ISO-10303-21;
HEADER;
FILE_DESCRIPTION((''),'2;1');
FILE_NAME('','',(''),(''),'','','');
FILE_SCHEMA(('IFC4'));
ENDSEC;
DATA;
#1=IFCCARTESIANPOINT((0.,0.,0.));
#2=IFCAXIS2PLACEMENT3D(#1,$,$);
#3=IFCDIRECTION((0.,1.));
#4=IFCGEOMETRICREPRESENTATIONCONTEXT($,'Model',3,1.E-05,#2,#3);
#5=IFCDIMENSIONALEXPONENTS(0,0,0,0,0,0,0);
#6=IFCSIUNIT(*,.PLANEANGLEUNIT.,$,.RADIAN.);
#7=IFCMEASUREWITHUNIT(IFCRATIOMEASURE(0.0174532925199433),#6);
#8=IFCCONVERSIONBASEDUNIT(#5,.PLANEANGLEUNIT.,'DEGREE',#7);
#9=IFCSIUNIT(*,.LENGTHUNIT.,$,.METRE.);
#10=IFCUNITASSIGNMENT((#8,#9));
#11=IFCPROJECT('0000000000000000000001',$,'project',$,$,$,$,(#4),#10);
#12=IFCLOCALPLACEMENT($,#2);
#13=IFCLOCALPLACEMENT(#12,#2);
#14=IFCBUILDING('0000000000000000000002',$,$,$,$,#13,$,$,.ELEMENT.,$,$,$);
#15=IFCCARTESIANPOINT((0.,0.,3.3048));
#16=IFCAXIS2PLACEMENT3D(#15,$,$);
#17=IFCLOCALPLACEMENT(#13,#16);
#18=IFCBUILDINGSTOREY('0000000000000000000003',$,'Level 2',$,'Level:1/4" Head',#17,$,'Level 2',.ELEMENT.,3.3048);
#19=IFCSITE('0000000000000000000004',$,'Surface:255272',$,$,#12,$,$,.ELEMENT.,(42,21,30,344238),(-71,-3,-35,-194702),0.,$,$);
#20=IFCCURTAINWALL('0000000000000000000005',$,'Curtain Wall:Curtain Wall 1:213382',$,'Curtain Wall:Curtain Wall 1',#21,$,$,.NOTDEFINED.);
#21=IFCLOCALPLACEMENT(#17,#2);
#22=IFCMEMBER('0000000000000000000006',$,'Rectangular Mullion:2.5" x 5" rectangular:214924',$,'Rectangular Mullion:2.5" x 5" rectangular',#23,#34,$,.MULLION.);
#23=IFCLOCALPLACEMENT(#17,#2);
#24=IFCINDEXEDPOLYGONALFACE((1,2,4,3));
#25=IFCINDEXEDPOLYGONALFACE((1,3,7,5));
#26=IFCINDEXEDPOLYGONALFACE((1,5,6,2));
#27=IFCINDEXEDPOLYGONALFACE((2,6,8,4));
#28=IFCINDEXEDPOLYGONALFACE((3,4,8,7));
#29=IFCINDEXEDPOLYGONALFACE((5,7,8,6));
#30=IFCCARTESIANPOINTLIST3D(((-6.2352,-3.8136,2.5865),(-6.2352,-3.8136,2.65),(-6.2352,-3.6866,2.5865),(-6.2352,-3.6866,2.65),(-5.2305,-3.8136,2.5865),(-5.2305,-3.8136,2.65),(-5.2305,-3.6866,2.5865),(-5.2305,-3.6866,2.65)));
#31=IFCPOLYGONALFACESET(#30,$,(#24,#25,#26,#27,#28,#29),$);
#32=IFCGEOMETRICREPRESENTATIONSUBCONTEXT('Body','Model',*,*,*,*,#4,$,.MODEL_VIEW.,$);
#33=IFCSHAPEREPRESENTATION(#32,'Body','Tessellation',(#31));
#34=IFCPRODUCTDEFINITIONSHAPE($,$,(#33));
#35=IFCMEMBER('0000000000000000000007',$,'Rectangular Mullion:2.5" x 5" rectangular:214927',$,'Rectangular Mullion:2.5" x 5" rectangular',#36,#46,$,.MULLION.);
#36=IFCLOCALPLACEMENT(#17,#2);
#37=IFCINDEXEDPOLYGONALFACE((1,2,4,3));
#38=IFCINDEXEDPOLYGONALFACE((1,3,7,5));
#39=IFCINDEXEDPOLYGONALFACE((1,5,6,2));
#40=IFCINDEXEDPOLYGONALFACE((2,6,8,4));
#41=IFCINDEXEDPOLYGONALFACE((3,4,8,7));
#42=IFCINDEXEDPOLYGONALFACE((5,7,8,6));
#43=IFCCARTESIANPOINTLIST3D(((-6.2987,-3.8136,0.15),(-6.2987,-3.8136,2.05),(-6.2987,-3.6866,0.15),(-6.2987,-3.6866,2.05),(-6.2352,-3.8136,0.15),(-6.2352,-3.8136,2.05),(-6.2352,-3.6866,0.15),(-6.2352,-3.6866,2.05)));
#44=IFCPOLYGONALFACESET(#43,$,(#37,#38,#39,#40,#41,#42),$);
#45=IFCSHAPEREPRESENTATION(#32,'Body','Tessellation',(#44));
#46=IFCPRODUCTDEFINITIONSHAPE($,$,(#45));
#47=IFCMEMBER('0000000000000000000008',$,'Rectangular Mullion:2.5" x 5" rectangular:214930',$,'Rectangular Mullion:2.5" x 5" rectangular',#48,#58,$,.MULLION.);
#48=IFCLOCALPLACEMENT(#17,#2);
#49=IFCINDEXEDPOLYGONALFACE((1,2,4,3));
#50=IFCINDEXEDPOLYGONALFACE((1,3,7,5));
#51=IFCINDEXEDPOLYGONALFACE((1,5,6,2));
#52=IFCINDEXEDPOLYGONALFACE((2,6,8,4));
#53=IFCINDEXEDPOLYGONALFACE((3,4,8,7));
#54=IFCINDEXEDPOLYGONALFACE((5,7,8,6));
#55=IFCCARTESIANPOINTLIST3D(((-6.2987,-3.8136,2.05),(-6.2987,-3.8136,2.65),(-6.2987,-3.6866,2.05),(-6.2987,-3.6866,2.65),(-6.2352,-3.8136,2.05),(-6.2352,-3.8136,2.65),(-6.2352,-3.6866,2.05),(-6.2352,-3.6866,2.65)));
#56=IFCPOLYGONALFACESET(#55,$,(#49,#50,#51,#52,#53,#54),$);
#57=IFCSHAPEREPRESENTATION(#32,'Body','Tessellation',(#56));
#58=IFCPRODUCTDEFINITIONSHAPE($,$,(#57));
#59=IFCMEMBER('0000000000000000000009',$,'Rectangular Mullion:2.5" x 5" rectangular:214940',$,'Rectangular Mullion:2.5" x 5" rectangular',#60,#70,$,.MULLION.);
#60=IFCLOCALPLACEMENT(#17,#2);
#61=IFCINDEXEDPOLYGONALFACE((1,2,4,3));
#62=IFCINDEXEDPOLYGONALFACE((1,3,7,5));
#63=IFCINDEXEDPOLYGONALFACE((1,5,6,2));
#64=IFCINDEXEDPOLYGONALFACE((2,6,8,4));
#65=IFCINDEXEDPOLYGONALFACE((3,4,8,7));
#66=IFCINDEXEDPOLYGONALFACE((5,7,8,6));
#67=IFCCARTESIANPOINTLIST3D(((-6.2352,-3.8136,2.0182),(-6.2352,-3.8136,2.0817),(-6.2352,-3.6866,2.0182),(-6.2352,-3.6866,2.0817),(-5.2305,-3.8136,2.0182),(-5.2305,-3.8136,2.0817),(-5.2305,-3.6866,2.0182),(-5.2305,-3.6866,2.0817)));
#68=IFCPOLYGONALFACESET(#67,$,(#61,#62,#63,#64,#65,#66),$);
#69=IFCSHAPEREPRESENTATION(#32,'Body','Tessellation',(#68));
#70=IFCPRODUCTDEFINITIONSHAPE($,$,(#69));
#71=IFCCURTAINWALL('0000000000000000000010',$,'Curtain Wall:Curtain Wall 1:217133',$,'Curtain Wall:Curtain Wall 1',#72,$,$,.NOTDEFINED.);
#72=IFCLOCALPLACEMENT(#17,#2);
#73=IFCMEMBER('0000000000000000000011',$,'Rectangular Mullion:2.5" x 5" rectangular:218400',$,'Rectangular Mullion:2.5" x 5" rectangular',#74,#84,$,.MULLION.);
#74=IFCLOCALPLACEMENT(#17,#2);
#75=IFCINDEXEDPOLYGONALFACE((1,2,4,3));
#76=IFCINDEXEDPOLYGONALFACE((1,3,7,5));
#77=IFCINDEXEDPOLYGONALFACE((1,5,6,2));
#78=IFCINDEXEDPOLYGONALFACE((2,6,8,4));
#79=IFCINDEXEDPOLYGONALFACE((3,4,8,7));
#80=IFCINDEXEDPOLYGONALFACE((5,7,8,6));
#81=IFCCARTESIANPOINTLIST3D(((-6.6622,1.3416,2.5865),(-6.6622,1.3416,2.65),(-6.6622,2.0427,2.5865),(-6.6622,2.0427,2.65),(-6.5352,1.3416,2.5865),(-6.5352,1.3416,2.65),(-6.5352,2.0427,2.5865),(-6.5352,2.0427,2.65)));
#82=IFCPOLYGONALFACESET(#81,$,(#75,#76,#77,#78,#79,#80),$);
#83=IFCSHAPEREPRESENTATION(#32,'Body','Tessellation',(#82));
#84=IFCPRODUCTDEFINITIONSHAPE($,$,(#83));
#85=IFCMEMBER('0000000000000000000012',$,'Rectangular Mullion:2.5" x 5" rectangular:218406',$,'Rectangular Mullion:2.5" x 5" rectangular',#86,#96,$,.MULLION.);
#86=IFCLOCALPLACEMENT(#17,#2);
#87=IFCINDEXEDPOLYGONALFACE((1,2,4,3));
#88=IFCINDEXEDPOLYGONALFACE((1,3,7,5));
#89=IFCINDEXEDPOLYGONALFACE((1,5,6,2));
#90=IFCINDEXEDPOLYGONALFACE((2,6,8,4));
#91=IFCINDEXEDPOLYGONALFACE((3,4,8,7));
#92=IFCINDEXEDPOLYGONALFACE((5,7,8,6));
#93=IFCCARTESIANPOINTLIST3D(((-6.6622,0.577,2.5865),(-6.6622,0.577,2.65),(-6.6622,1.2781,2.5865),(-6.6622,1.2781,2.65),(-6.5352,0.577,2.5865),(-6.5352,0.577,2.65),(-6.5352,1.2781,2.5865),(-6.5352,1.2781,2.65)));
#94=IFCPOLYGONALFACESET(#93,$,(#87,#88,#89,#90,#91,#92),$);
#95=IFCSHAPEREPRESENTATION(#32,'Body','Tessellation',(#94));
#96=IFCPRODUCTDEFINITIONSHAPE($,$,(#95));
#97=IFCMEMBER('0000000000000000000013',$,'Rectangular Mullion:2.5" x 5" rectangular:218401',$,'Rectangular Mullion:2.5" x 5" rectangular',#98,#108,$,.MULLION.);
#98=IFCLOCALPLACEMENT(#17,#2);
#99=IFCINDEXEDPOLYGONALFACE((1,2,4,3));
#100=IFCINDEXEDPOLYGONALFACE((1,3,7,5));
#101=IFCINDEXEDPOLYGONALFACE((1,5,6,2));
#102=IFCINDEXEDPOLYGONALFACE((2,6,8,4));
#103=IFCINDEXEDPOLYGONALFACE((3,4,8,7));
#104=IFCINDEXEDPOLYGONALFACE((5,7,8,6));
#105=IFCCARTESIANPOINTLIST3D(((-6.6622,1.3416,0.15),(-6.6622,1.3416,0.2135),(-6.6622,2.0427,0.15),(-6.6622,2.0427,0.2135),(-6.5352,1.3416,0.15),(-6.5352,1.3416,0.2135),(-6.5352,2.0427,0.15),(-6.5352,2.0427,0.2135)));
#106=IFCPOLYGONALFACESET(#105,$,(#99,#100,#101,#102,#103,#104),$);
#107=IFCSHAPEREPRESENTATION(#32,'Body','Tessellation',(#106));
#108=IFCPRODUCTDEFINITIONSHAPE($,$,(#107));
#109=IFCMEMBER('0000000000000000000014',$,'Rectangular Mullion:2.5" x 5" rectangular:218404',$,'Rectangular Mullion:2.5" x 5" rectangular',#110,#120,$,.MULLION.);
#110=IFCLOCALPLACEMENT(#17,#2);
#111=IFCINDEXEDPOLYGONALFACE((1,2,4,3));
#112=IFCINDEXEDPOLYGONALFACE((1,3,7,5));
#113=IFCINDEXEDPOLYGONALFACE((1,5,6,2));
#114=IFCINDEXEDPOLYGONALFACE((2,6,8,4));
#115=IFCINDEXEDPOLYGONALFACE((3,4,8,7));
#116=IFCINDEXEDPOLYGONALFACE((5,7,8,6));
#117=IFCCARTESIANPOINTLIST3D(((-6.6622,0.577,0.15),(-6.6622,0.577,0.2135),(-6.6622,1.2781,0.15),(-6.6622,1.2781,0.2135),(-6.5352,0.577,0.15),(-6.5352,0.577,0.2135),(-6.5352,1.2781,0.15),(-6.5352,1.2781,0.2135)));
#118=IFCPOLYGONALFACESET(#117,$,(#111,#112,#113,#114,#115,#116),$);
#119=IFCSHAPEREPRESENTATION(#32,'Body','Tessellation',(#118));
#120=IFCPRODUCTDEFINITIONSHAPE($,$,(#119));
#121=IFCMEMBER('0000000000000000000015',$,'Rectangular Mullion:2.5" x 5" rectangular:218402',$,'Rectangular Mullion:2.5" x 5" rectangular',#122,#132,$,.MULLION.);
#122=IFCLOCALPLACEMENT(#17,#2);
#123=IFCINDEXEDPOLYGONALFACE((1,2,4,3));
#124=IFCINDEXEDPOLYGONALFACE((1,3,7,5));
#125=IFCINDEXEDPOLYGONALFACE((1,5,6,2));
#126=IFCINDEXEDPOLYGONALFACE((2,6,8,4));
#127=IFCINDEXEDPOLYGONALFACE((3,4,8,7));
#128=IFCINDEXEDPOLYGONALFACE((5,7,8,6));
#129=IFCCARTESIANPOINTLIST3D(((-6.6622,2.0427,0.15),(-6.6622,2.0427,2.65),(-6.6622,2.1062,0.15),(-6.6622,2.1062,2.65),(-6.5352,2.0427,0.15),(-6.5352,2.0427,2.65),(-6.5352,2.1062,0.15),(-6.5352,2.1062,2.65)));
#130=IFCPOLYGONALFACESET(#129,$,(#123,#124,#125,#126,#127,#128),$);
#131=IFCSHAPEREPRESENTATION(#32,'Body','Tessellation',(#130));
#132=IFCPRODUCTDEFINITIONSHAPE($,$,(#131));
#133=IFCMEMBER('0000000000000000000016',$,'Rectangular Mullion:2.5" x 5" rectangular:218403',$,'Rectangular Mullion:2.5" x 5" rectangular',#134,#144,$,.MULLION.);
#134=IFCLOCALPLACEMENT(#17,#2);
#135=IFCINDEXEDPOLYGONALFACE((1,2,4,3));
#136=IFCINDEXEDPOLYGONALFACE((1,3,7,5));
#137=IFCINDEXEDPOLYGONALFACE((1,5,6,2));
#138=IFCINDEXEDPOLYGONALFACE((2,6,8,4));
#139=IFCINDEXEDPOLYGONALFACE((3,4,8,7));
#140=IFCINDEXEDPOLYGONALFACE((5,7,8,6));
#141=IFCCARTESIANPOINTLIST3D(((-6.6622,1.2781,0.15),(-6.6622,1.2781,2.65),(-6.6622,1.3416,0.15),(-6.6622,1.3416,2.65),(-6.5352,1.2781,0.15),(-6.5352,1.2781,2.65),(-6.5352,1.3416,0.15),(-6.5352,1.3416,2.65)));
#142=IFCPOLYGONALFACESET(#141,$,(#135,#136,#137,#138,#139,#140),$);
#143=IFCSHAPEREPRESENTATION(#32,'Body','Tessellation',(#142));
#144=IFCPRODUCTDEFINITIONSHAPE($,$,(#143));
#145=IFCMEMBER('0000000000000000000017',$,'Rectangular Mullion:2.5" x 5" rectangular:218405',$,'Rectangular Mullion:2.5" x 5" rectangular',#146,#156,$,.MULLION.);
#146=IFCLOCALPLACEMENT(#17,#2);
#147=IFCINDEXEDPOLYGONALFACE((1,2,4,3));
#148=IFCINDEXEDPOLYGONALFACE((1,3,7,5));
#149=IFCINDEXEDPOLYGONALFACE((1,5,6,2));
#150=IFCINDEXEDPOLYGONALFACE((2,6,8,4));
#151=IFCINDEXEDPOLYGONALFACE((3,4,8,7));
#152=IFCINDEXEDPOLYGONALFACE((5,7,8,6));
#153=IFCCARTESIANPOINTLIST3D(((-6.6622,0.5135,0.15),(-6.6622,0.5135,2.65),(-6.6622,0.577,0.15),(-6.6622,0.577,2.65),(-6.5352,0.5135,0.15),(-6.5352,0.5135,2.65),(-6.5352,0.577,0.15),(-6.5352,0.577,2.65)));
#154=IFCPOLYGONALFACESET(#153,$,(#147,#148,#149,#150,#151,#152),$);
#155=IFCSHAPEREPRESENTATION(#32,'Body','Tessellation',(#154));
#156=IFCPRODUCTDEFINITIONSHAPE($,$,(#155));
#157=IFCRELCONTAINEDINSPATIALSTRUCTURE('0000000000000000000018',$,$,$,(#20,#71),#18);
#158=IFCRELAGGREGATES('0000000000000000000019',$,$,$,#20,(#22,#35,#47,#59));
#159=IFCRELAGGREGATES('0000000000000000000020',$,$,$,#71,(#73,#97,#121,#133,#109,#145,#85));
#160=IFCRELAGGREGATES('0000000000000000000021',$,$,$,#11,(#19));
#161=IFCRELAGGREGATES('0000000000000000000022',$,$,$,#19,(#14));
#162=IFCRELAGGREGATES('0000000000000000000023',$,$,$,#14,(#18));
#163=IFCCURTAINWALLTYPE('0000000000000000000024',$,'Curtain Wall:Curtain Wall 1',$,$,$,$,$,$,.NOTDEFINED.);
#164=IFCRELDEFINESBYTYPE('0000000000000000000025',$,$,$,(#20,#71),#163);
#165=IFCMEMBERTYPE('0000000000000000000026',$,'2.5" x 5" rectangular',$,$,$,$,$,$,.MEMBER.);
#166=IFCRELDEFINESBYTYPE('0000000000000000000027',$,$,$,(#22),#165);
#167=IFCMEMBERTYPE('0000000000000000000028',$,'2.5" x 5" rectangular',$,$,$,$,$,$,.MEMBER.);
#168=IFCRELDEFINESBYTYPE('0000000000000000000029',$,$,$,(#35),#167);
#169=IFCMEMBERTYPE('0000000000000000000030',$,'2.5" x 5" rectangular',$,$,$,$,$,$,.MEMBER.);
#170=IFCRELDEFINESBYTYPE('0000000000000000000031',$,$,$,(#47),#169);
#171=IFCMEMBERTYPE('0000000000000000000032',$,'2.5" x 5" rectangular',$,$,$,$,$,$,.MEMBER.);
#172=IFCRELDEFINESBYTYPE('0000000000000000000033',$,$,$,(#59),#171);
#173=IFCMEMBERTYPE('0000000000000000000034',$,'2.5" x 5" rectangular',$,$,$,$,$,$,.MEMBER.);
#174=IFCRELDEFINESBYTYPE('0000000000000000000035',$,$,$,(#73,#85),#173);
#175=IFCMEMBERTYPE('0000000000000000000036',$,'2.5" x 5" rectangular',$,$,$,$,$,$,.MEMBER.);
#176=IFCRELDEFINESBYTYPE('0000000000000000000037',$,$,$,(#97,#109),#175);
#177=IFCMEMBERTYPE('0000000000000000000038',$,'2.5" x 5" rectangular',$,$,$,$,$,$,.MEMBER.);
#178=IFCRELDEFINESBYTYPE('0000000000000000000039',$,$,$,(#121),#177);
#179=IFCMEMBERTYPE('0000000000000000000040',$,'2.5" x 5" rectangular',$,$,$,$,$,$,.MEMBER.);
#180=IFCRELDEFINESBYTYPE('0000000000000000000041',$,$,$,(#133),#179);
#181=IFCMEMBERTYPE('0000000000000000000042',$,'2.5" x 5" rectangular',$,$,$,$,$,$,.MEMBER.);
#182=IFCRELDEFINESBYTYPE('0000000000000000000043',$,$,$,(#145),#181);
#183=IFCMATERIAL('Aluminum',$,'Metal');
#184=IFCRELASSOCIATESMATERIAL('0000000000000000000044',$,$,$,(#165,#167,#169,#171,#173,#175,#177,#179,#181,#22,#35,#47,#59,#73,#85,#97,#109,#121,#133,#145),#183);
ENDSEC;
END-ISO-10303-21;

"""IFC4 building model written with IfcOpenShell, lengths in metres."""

from ifc_helpers import new_model, entity, si_unit, converted_unit, direction, frame, origin, origin_2d_with_axis, place, context, subcontext, project, spatial, rectangle, extrude, source, transform, mapped, material, material_profile, profile_set, profile_usage, type_object, type_shapes, element, aggregate, save


model = new_model("IFC4")

# Units and contexts
model_context = context("Model", 3, precision=1e-05, world=origin(), true_north=direction((0.0, 1.0)))
body_context = subcontext(model_context, "Body", "Model", "MODEL_VIEW")
ifc_project = project(units=[converted_unit("PLANEANGLEUNIT", "DEGREE", entity("IfcRatioMeasure", 0.0174532925199433), si_unit("PLANEANGLEUNIT", "RADIAN"), dimensions=[0, 0, 0, 0, 0, 0, 0]), si_unit("LENGTHUNIT", "METRE")], contexts=[model_context])

# Site, building, storey
site_placement = place(None, origin())
site = spatial("IfcSite", under=ifc_project, at=site_placement, Name="Surface:255272", CompositionType="ELEMENT", RefLatitude=(42, 21, 30, 344238), RefLongitude=(-71, -3, -35, -194702), RefElevation=0.0)
building_placement = place(site_placement, origin())
building = spatial("IfcBuilding", under=site, at=building_placement, CompositionType="ELEMENT")
storey_placement = place(building_placement, frame((0.0, 0.0, 3.3048)))
storey = spatial("IfcBuildingStorey", under=building, at=storey_placement, Name="Level 2", ObjectType="Level:1/4\" Head", LongName="Level 2", CompositionType="ELEMENT", Elevation=3.3048)

# Curtain walls, members
curtain_wall_type = type_object("IfcCurtainWallType", Name="Curtain Wall:Curtain Wall 1", PredefinedType="NOTDEFINED")
curtain_wall_1_placement = place(storey_placement, frame((0.0, 0.0, -3.3048)))
curtain_wall_1 = element("IfcCurtainWall", 1, at=curtain_wall_1_placement, inside=storey, type_object=curtain_wall_type, Name="Curtain Wall:Curtain Wall 1:213382", ObjectType="Curtain Wall:Curtain Wall 1", PredefinedType="NOTDEFINED")
ifc_material_1 = material(Name="Aluminum", Category="Metal")
ifc_material_profile = material_profile(ifc_material_1, rectangle(XDim=0.127, YDim=0.0635, at=origin_2d_with_axis()), Name="2.5\" x 5\" rectangular")
ifc_profile_set = profile_set([ifc_material_profile], Name="2.5\" x 5\" rectangular")
ifc_profile_usage_1 = profile_usage(ifc_profile_set)
member_type_1 = type_object("IfcMemberType", Name="2.5\" x 5\" rectangular", PredefinedType="MEMBER", material=ifc_profile_set)
shared_shape_1 = source(origin(), body_context, "Body", "SweptSolid", [
    extrude(rectangle(XDim=0.127, YDim=0.0635, at=origin_2d_with_axis()), frame((-0.0318, 0.0, -1.0048), z_axis=(0.0, 0.0, 1.0), x_axis=(0.0, -1.0, 0.0)), (0.0, 0.0, 1.0), 1.0048),
])
type_shapes(member_type_1, [shared_shape_1])
member_1_placement = place(storey_placement, frame((-6.2352, -3.7501, 2.65), z_axis=(-1.0, 0.000007, 0.0), x_axis=(0.0, 0.0, 1.0)))
member_1 = element("IfcMember", 2, at=member_1_placement, type_object=member_type_1, material=ifc_profile_usage_1, Name="Rectangular Mullion:2.5\" x 5\" rectangular:214924", ObjectType="Rectangular Mullion:2.5\" x 5\" rectangular", PredefinedType="MULLION", context=body_context, shape_type="MappedRepresentation", body=[
    mapped(shared_shape_1, transform((0.0, 0.0, 0.0), scale=1.0)),
])
ifc_profile_usage_2 = profile_usage(ifc_profile_set)
member_type_2 = type_object("IfcMemberType", Name="2.5\" x 5\" rectangular", PredefinedType="MEMBER", material=ifc_profile_set)
shared_shape_2 = source(origin(), body_context, "Body", "SweptSolid", [
    extrude(rectangle(XDim=0.127, YDim=0.0635, at=origin_2d_with_axis()), frame((-0.0318, 0.0, -1.9), z_axis=(0.0, 0.0, 1.0), x_axis=(0.0, -1.0, 0.0)), (0.0, 0.0, 1.0), 1.9),
])
type_shapes(member_type_2, [shared_shape_2])
member_2_placement = place(storey_placement, frame((-6.2987, -3.7501, 0.15), z_axis=(0.0, 0.0, -1.0), x_axis=(-1.0, 0.000007, 0.0)))
member_2 = element("IfcMember", 3, at=member_2_placement, type_object=member_type_2, material=ifc_profile_usage_2, Name="Rectangular Mullion:2.5\" x 5\" rectangular:214927", ObjectType="Rectangular Mullion:2.5\" x 5\" rectangular", PredefinedType="MULLION", context=body_context, shape_type="MappedRepresentation", body=[
    mapped(shared_shape_2, transform((0.0, 0.0, 0.0), scale=1.0)),
])
ifc_profile_usage_3 = profile_usage(ifc_profile_set)
member_type_3 = type_object("IfcMemberType", Name="2.5\" x 5\" rectangular", PredefinedType="MEMBER", material=ifc_profile_set)
shared_shape_3 = source(origin(), body_context, "Body", "SweptSolid", [
    extrude(rectangle(XDim=0.127, YDim=0.0635, at=origin_2d_with_axis()), frame((-0.0318, 0.0, -0.6), z_axis=(0.0, 0.0, 1.0), x_axis=(0.0, -1.0, 0.0)), (0.0, 0.0, 1.0), 0.6),
])
type_shapes(member_type_3, [shared_shape_3])
member_3_placement = place(storey_placement, frame((-6.2987, -3.7501, 2.05), z_axis=(0.0, 0.0, -1.0), x_axis=(-1.0, 0.000007, 0.0)))
member_3 = element("IfcMember", 4, at=member_3_placement, type_object=member_type_3, material=ifc_profile_usage_3, Name="Rectangular Mullion:2.5\" x 5\" rectangular:214930", ObjectType="Rectangular Mullion:2.5\" x 5\" rectangular", PredefinedType="MULLION", context=body_context, shape_type="MappedRepresentation", body=[
    mapped(shared_shape_3, transform((0.0, 0.0, 0.0), scale=1.0)),
])
ifc_profile_usage_4 = profile_usage(ifc_profile_set)
member_type_4 = type_object("IfcMemberType", Name="2.5\" x 5\" rectangular", PredefinedType="MEMBER", material=ifc_profile_set)
shared_shape_4 = source(origin(), body_context, "Body", "SweptSolid", [
    extrude(rectangle(XDim=0.127, YDim=0.0635, at=origin_2d_with_axis()), frame((0.0, 0.0, -1.0048), z_axis=(0.0, 0.0, 1.0), x_axis=(0.0, -1.0, 0.0)), (0.0, 0.0, 1.0), 1.0048),
])
type_shapes(member_type_4, [shared_shape_4])
member_4_placement = place(storey_placement, frame((-6.2352, -3.7501, 2.05), z_axis=(-1.0, 0.000007, 0.0), x_axis=(0.0, 0.0, 1.0)))
member_4 = element("IfcMember", 5, at=member_4_placement, type_object=member_type_4, material=ifc_profile_usage_4, Name="Rectangular Mullion:2.5\" x 5\" rectangular:214940", ObjectType="Rectangular Mullion:2.5\" x 5\" rectangular", PredefinedType="MULLION", context=body_context, shape_type="MappedRepresentation", body=[
    mapped(shared_shape_4, transform((0.0, 0.0, 0.0), scale=1.0)),
])
curtain_wall_2_placement = place(storey_placement, frame((0.0, 0.0, -3.3048)))
curtain_wall_2 = element("IfcCurtainWall", 6, at=curtain_wall_2_placement, inside=storey, type_object=curtain_wall_type, Name="Curtain Wall:Curtain Wall 1:217133", ObjectType="Curtain Wall:Curtain Wall 1", PredefinedType="NOTDEFINED")
ifc_profile_usage_5 = profile_usage(ifc_profile_set)
member_type_5 = type_object("IfcMemberType", Name="2.5\" x 5\" rectangular", PredefinedType="MEMBER", material=ifc_profile_set)
shared_shape_5 = source(origin(), body_context, "Body", "SweptSolid", [
    extrude(rectangle(XDim=0.127, YDim=0.0635, at=origin_2d_with_axis()), frame((-0.0318, 0.0, -0.7011), z_axis=(0.0, 0.0, 1.0), x_axis=(0.0, -1.0, 0.0)), (0.0, 0.0, 1.0), 0.7011),
])
type_shapes(member_type_5, [shared_shape_5])
member_5_placement = place(storey_placement, frame((-6.5987, 2.0427, 2.65), z_axis=(0.000007, 1.0, 0.0), x_axis=(0.0, 0.0, 1.0)))
member_5 = element("IfcMember", 7, at=member_5_placement, type_object=member_type_5, material=ifc_profile_usage_5, Name="Rectangular Mullion:2.5\" x 5\" rectangular:218400", ObjectType="Rectangular Mullion:2.5\" x 5\" rectangular", PredefinedType="MULLION", context=body_context, shape_type="MappedRepresentation", body=[
    mapped(shared_shape_5, transform((0.0, 0.0, 0.0), scale=1.0)),
])
ifc_profile_usage_6 = profile_usage(ifc_profile_set)
member_6_placement = place(storey_placement, frame((-6.5987, 1.2781, 2.65), z_axis=(0.000007, 1.0, 0.0), x_axis=(0.0, 0.0, 1.0)))
member_6 = element("IfcMember", 8, at=member_6_placement, type_object=member_type_5, material=ifc_profile_usage_6, Name="Rectangular Mullion:2.5\" x 5\" rectangular:218406", ObjectType="Rectangular Mullion:2.5\" x 5\" rectangular", PredefinedType="MULLION", context=body_context, shape_type="MappedRepresentation", body=[
    mapped(shared_shape_5, transform((0.0, 0.0, 0.0), scale=1.0)),
])
ifc_profile_usage_7 = profile_usage(ifc_profile_set)
member_type_6 = type_object("IfcMemberType", Name="2.5\" x 5\" rectangular", PredefinedType="MEMBER", material=ifc_profile_set)
shared_shape_6 = source(origin(), body_context, "Body", "SweptSolid", [
    extrude(rectangle(XDim=0.127, YDim=0.0635, at=origin_2d_with_axis()), frame((-0.0318, 0.0, -0.7011), z_axis=(0.0, 0.0, 1.0), x_axis=(0.0, -1.0, 0.0)), (0.0, 0.0, 1.0), 0.7011),
])
type_shapes(member_type_6, [shared_shape_6])
member_7_placement = place(storey_placement, frame((-6.5987, 1.3416, 0.15), z_axis=(-0.000007, -1.0, 0.0), x_axis=(0.0, 0.0, -1.0)))
member_7 = element("IfcMember", 9, at=member_7_placement, type_object=member_type_6, material=ifc_profile_usage_7, Name="Rectangular Mullion:2.5\" x 5\" rectangular:218401", ObjectType="Rectangular Mullion:2.5\" x 5\" rectangular", PredefinedType="MULLION", context=body_context, shape_type="MappedRepresentation", body=[
    mapped(shared_shape_6, transform((0.0, 0.0, 0.0), scale=1.0)),
])
ifc_profile_usage_8 = profile_usage(ifc_profile_set)
member_8_placement = place(storey_placement, frame((-6.5987, 0.577, 0.15), z_axis=(-0.000007, -1.0, 0.0), x_axis=(0.0, 0.0, -1.0)))
member_8 = element("IfcMember", 10, at=member_8_placement, type_object=member_type_6, material=ifc_profile_usage_8, Name="Rectangular Mullion:2.5\" x 5\" rectangular:218404", ObjectType="Rectangular Mullion:2.5\" x 5\" rectangular", PredefinedType="MULLION", context=body_context, shape_type="MappedRepresentation", body=[
    mapped(shared_shape_6, transform((0.0, 0.0, 0.0), scale=1.0)),
])
ifc_profile_usage_9 = profile_usage(ifc_profile_set)
member_type_7 = type_object("IfcMemberType", Name="2.5\" x 5\" rectangular", PredefinedType="MEMBER", material=ifc_profile_set)
shared_shape_7 = source(origin(), body_context, "Body", "SweptSolid", [
    extrude(rectangle(XDim=0.127, YDim=0.0635, at=origin_2d_with_axis()), frame((-0.0318, 0.0, -2.5), z_axis=(0.0, 0.0, 1.0), x_axis=(0.0, -1.0, 0.0)), (0.0, 0.0, 1.0), 2.5),
])
type_shapes(member_type_7, [shared_shape_7])
member_9_placement = place(storey_placement, frame((-6.5987, 2.1062, 0.15), z_axis=(0.0, 0.0, -1.0), x_axis=(0.000007, 1.0, 0.0)))
member_9 = element("IfcMember", 11, at=member_9_placement, type_object=member_type_7, material=ifc_profile_usage_9, Name="Rectangular Mullion:2.5\" x 5\" rectangular:218402", ObjectType="Rectangular Mullion:2.5\" x 5\" rectangular", PredefinedType="MULLION", context=body_context, shape_type="MappedRepresentation", body=[
    mapped(shared_shape_7, transform((0.0, 0.0, 0.0), scale=1.0)),
])
ifc_profile_usage_10 = profile_usage(ifc_profile_set)
member_type_8 = type_object("IfcMemberType", Name="2.5\" x 5\" rectangular", PredefinedType="MEMBER", material=ifc_profile_set)
shared_shape_8 = source(origin(), body_context, "Body", "SweptSolid", [
    extrude(rectangle(XDim=0.127, YDim=0.0635, at=origin_2d_with_axis()), frame((0.0, 0.0, -2.5), z_axis=(0.0, 0.0, 1.0), x_axis=(0.0, -1.0, 0.0)), (0.0, 0.0, 1.0), 2.5),
])
type_shapes(member_type_8, [shared_shape_8])
member_10_placement = place(storey_placement, frame((-6.5987, 1.3099, 0.15), z_axis=(0.0, 0.0, -1.0), x_axis=(0.000007, 1.0, 0.0)))
member_10 = element("IfcMember", 12, at=member_10_placement, type_object=member_type_8, material=ifc_profile_usage_10, Name="Rectangular Mullion:2.5\" x 5\" rectangular:218403", ObjectType="Rectangular Mullion:2.5\" x 5\" rectangular", PredefinedType="MULLION", context=body_context, shape_type="MappedRepresentation", body=[
    mapped(shared_shape_8, transform((0.0, 0.0, 0.0), scale=1.0)),
])
ifc_profile_usage_11 = profile_usage(ifc_profile_set)
member_type_9 = type_object("IfcMemberType", Name="2.5\" x 5\" rectangular", PredefinedType="MEMBER", material=ifc_profile_set)
shared_shape_9 = source(origin(), body_context, "Body", "SweptSolid", [
    extrude(rectangle(XDim=0.127, YDim=0.0635, at=origin_2d_with_axis()), frame((-0.0318, 0.0, -2.5), z_axis=(0.0, 0.0, 1.0), x_axis=(0.0, -1.0, 0.0)), (0.0, 0.0, 1.0), 2.5),
])
type_shapes(member_type_9, [shared_shape_9])
member_11_placement = place(storey_placement, frame((-6.5987, 0.5135, 2.65), z_axis=(0.0, 0.0, 1.0), x_axis=(-0.000007, -1.0, 0.0)))
member_11 = element("IfcMember", 13, at=member_11_placement, type_object=member_type_9, material=ifc_profile_usage_11, Name="Rectangular Mullion:2.5\" x 5\" rectangular:218405", ObjectType="Rectangular Mullion:2.5\" x 5\" rectangular", PredefinedType="MULLION", context=body_context, shape_type="MappedRepresentation", body=[
    mapped(shared_shape_9, transform((0.0, 0.0, 0.0), scale=1.0)),
])

aggregate(curtain_wall_1, [member_1, member_2, member_3, member_4])
aggregate(curtain_wall_2, [member_5, member_7, member_9, member_10, member_8, member_11, member_6])

save(model, "model.ifc")
